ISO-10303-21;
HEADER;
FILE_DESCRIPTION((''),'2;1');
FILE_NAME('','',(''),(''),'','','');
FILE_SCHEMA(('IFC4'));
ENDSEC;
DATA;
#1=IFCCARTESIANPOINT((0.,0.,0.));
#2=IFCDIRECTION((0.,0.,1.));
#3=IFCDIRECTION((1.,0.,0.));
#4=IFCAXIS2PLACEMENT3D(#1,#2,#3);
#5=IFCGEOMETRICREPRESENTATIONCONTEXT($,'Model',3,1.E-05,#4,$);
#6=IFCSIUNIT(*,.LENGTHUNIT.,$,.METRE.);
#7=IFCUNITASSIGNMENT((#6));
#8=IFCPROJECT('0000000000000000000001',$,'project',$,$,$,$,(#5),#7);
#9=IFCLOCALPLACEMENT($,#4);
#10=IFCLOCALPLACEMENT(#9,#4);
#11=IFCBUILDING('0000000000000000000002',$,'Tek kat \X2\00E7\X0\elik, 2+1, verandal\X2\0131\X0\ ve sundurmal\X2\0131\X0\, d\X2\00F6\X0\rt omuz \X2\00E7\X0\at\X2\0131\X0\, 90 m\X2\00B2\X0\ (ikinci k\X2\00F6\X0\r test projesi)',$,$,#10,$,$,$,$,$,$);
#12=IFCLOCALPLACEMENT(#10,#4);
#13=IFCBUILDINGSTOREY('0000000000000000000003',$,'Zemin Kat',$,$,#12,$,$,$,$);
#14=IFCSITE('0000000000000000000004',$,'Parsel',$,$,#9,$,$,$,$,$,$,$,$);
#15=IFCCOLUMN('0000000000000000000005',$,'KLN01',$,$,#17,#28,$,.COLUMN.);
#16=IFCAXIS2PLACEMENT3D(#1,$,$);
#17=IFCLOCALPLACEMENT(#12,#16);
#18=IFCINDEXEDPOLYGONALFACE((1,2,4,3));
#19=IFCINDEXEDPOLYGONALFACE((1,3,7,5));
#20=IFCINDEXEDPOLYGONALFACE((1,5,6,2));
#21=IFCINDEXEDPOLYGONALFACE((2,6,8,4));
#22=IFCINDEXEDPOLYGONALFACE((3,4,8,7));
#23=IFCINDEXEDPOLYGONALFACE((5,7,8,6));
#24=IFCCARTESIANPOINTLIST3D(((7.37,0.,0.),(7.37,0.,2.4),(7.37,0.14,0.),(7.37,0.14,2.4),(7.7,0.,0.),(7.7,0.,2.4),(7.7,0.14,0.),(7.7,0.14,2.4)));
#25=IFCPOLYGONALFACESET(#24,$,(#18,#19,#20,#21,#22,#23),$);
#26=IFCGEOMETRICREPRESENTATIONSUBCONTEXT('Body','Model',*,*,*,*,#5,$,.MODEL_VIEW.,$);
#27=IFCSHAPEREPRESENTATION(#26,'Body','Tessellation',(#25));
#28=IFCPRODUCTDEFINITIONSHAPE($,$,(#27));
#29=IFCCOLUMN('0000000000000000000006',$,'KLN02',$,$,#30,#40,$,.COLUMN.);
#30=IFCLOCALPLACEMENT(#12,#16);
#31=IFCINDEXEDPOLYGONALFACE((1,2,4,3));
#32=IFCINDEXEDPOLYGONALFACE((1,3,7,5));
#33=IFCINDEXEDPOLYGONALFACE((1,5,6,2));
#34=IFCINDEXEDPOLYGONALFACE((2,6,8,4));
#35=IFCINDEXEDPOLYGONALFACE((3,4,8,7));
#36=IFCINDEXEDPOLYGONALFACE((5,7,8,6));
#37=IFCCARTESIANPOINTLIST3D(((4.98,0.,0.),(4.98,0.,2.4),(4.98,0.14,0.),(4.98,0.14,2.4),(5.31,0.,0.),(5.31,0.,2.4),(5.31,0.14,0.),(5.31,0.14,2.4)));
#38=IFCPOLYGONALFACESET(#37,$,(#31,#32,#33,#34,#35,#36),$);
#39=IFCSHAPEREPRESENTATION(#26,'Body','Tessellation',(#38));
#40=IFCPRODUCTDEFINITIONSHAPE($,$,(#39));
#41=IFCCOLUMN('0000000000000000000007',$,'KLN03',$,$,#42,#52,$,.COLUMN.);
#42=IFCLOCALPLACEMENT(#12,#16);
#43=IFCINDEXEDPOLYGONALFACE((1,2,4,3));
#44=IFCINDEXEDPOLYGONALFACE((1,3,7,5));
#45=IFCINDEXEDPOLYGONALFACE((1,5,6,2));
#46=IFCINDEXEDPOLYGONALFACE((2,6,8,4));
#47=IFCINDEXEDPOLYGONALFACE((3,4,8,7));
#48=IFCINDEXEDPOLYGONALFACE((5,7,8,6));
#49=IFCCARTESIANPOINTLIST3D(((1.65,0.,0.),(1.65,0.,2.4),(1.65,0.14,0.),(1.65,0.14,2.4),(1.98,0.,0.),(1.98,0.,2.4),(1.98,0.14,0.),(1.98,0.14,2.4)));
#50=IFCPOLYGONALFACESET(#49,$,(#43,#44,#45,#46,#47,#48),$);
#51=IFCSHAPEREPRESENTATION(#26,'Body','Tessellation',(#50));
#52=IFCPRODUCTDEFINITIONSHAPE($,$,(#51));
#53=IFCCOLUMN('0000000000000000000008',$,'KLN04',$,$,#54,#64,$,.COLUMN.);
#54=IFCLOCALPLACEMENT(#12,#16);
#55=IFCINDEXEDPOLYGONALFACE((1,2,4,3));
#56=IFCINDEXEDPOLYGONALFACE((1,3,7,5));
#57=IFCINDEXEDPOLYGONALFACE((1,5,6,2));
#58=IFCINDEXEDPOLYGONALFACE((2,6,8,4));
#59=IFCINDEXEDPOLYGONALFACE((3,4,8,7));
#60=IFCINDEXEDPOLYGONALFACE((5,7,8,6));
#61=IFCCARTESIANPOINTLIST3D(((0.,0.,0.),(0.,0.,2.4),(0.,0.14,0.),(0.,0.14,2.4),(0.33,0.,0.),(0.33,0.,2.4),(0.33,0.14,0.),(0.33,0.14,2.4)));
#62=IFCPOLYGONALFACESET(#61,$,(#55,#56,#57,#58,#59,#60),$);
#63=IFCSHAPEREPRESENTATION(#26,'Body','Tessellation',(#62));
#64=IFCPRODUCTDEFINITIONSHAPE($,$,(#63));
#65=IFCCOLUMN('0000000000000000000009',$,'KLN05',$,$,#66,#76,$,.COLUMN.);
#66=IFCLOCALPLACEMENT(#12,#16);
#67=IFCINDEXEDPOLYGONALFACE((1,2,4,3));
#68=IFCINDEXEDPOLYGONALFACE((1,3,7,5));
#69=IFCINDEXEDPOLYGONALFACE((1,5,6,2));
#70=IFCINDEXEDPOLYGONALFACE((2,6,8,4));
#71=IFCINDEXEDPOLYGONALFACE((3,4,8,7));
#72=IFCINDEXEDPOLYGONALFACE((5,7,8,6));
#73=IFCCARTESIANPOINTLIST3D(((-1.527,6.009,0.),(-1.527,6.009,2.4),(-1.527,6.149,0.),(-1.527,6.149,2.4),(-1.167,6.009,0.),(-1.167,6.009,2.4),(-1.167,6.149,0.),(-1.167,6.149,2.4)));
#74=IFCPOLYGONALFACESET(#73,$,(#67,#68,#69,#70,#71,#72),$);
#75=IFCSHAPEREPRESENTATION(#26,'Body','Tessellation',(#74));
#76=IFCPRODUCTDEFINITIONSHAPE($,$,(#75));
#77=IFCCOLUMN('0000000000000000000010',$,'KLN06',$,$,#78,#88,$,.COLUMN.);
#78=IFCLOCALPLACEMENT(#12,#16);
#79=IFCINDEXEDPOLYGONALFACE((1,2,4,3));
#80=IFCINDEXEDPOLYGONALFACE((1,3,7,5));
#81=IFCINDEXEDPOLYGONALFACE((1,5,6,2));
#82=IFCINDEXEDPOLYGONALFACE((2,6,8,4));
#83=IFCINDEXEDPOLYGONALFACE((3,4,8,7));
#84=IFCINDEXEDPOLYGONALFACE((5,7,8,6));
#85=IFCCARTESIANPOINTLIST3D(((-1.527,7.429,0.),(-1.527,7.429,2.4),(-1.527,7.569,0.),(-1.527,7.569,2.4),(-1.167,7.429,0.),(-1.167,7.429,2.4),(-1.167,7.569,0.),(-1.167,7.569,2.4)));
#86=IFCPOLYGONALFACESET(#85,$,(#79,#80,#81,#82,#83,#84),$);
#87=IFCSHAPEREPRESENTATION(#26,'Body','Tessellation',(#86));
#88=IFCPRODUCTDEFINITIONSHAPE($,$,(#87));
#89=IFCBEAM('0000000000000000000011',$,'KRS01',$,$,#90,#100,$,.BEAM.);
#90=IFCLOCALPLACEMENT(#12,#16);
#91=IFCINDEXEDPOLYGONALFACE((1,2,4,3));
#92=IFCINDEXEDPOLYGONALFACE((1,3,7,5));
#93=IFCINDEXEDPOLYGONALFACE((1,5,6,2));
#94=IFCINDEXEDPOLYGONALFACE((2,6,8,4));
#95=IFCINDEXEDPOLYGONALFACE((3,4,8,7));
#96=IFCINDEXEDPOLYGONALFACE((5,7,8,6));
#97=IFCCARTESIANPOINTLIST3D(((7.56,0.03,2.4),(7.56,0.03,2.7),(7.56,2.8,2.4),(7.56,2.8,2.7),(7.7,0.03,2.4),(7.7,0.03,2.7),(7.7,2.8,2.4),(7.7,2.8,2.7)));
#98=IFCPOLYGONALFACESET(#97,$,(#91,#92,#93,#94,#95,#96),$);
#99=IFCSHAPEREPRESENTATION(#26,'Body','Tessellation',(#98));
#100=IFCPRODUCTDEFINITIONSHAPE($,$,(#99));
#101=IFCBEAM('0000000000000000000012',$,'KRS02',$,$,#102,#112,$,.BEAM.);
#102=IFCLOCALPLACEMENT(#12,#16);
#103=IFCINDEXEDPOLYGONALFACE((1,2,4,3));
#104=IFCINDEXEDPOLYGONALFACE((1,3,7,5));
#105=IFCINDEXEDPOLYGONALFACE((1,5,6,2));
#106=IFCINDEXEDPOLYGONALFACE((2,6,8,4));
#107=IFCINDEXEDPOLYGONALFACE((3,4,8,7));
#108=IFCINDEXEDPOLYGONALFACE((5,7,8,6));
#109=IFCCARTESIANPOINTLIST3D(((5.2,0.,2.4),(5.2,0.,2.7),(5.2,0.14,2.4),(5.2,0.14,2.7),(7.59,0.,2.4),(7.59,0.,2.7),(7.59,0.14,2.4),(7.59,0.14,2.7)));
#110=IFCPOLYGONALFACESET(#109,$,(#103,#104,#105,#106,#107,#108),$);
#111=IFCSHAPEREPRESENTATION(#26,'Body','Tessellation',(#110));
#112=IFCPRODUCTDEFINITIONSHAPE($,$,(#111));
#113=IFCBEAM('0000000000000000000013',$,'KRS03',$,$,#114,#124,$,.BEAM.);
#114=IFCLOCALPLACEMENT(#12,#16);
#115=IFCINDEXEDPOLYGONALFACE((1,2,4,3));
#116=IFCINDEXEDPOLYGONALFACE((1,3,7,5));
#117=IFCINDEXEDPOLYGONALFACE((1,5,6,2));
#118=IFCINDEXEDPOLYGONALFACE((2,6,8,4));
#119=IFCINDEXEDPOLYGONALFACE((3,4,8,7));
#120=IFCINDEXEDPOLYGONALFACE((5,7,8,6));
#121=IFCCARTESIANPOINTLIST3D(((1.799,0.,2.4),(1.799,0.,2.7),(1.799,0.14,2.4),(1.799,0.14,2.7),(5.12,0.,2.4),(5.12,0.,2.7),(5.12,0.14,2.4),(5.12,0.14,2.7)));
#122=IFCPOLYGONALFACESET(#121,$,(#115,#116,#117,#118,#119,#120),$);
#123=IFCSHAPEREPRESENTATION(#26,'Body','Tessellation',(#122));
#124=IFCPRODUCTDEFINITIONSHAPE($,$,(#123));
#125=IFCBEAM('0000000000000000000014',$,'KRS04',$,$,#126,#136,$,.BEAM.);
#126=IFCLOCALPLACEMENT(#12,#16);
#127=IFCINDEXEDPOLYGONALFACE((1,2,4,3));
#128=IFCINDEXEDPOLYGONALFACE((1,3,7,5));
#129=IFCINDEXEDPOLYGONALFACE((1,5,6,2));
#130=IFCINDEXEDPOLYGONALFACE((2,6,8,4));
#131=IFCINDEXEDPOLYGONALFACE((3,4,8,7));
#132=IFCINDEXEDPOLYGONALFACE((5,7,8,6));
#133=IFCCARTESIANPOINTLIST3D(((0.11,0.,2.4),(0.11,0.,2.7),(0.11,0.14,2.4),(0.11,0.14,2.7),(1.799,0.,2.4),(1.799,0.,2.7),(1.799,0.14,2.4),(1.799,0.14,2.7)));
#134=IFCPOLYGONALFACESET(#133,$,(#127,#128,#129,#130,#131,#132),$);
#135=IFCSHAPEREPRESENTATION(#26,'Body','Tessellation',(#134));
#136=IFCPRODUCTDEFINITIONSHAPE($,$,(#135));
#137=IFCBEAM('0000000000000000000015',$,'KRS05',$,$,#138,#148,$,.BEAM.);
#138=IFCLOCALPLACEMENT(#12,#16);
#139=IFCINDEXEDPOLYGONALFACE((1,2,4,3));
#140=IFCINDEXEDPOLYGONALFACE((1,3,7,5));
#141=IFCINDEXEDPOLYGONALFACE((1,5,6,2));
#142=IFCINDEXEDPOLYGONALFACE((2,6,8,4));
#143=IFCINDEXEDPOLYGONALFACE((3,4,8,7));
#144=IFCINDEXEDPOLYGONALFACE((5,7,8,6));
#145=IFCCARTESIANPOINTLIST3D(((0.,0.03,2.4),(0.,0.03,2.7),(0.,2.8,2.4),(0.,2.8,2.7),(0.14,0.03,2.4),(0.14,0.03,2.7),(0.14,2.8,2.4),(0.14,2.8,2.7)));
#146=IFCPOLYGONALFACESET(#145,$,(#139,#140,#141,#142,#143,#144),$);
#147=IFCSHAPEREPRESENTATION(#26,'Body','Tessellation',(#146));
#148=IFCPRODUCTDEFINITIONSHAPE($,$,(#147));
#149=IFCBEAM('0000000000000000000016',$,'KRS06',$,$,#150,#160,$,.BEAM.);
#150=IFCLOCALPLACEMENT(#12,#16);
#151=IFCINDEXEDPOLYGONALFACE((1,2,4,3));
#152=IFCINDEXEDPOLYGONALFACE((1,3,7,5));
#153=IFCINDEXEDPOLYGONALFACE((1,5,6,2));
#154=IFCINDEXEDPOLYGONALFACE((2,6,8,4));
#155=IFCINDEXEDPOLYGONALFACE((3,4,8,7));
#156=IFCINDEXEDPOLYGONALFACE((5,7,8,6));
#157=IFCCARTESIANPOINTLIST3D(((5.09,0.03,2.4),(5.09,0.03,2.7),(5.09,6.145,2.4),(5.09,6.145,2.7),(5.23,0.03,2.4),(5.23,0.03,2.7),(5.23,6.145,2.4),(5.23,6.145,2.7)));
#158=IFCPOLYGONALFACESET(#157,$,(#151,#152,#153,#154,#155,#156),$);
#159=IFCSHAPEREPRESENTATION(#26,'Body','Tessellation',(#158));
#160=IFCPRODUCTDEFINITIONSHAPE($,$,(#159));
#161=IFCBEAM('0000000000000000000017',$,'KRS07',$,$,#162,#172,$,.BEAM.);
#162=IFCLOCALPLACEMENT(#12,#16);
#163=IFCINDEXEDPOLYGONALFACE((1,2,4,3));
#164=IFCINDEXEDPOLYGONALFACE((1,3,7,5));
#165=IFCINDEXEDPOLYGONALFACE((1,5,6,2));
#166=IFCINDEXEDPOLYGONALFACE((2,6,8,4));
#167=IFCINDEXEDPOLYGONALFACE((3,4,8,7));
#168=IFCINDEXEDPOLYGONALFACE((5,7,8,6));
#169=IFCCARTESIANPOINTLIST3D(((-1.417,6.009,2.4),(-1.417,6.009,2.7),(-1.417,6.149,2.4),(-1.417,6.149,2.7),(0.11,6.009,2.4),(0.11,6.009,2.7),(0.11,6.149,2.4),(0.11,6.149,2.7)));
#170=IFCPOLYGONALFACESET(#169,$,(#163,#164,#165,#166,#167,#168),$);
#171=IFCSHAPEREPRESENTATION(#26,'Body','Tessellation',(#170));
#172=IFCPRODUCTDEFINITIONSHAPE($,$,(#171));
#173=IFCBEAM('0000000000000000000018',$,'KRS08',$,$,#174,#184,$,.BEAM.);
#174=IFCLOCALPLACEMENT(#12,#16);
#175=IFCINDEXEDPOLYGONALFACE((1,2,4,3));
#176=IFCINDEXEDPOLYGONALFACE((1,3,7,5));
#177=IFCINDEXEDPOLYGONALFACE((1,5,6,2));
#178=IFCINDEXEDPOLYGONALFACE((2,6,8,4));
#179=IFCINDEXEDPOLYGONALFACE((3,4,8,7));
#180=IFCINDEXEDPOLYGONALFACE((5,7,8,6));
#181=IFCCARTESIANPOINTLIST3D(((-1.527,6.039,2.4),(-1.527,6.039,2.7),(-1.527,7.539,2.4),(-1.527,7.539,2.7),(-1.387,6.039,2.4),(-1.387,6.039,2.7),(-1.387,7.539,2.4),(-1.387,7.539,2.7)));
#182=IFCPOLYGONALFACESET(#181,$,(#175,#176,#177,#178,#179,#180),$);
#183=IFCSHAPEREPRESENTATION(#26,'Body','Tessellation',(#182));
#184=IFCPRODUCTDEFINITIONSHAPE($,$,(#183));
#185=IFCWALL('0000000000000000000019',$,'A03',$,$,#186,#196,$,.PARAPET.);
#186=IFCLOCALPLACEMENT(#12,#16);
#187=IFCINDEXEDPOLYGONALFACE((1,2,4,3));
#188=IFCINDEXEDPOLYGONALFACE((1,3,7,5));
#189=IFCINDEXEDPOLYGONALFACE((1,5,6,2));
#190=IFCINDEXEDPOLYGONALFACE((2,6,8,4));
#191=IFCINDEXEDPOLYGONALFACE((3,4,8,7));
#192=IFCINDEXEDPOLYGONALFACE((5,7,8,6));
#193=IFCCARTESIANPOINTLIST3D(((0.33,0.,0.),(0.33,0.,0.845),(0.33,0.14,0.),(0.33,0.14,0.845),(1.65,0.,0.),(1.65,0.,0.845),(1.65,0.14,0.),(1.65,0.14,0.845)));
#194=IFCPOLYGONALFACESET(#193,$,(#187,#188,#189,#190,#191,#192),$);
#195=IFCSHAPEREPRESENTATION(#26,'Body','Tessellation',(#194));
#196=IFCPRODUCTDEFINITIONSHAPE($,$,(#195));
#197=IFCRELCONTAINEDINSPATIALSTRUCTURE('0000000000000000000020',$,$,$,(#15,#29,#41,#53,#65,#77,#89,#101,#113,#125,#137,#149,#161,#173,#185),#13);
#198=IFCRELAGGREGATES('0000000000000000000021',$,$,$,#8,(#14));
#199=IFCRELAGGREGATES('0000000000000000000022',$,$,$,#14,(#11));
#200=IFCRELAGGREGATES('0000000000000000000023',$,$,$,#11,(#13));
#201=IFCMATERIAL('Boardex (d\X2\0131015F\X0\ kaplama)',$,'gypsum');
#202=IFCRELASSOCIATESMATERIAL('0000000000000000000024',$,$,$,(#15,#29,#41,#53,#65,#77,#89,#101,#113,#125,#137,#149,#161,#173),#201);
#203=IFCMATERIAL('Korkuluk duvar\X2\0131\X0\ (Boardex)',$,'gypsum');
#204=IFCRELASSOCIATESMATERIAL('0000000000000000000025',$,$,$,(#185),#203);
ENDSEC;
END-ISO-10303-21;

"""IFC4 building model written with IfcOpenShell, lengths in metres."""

from ifc_helpers import new_model, si_unit, frame, origin_with_axes, place, context, subcontext, project, spatial, line, indexed_curve, outline, extrude, material, element, save


model = new_model("IFC4")

# Units and contexts
model_context = context("Model", 3, precision=1e-05, world=origin_with_axes())
body_context = subcontext(model_context, "Body", "Model", "MODEL_VIEW")
ifc_project = project(units=[si_unit("LENGTHUNIT", "METRE")], contexts=[model_context])

# Site, building, storey
site_placement = place(None, origin_with_axes())
site = spatial("IfcSite", under=ifc_project, at=site_placement, Name="Parsel")
building_placement = place(site_placement, origin_with_axes())
building = spatial("IfcBuilding", under=site, at=building_placement, Name="Tek kat çelik, 2+1, verandalı ve sundurmalı, dört omuz çatı, 90 m² (ikinci kör test projesi)")
storey_placement = place(building_placement, origin_with_axes())
storey = spatial("IfcBuildingStorey", under=building, at=storey_placement, Name="Zemin Kat")

# Columns
ifc_material_1 = material(Name="Boardex (dış kaplama)", Category="gypsum")
column_1_placement = place(storey_placement, origin_with_axes())
element("IfcColumn", 1, at=column_1_placement, inside=storey, material=ifc_material_1, Name="KLN01", PredefinedType="COLUMN", context=body_context, shape_type="SweptSolid", body=[
    extrude(outline(indexed_curve([(0.0, 0.0), (0.33, 0.0), (0.33, 0.14), (0.0, 0.14)], segments=[line(1, 2, 3, 4, 1)])), frame((7.37, 0.0, 0.0), z_axis=(0.0, 0.0, 1.0), x_axis=(1.0, 0.0, 0.0)), (0.0, 0.0, 1.0), 2.4),
])
column_2_placement = place(storey_placement, origin_with_axes())
element("IfcColumn", 2, at=column_2_placement, inside=storey, material=ifc_material_1, Name="KLN02", PredefinedType="COLUMN", context=body_context, shape_type="SweptSolid", body=[
    extrude(outline(indexed_curve([(0.0, 0.0), (0.33, 0.0), (0.33, 0.14), (0.0, 0.14)], segments=[line(1, 2, 3, 4, 1)])), frame((4.98, 0.0, 0.0), z_axis=(0.0, 0.0, 1.0), x_axis=(1.0, 0.0, 0.0)), (0.0, 0.0, 1.0), 2.4),
])
column_3_placement = place(storey_placement, origin_with_axes())
element("IfcColumn", 3, at=column_3_placement, inside=storey, material=ifc_material_1, Name="KLN03", PredefinedType="COLUMN", context=body_context, shape_type="SweptSolid", body=[
    extrude(outline(indexed_curve([(0.0, 0.0), (0.33, 0.0), (0.33, 0.14), (0.0, 0.14)], segments=[line(1, 2, 3, 4, 1)])), frame((1.65, 0.0, 0.0), z_axis=(0.0, 0.0, 1.0), x_axis=(1.0, 0.0, 0.0)), (0.0, 0.0, 1.0), 2.4),
])
column_4_placement = place(storey_placement, origin_with_axes())
element("IfcColumn", 4, at=column_4_placement, inside=storey, material=ifc_material_1, Name="KLN04", PredefinedType="COLUMN", context=body_context, shape_type="SweptSolid", body=[
    extrude(outline(indexed_curve([(0.0, 0.0), (0.33, 0.0), (0.33, 0.14), (0.0, 0.14)], segments=[line(1, 2, 3, 4, 1)])), origin_with_axes(), (0.0, 0.0, 1.0), 2.4),
])
column_5_placement = place(storey_placement, origin_with_axes())
element("IfcColumn", 5, at=column_5_placement, inside=storey, material=ifc_material_1, Name="KLN05", PredefinedType="COLUMN", context=body_context, shape_type="SweptSolid", body=[
    extrude(outline(indexed_curve([(0.0, 0.0), (0.36, 0.0), (0.36, 0.14), (0.0, 0.14)], segments=[line(1, 2, 3, 4, 1)])), frame((-1.527, 6.009, 0.0), z_axis=(0.0, 0.0, 1.0), x_axis=(1.0, 0.0, 0.0)), (0.0, 0.0, 1.0), 2.4),
])
column_6_placement = place(storey_placement, origin_with_axes())
element("IfcColumn", 6, at=column_6_placement, inside=storey, material=ifc_material_1, Name="KLN06", PredefinedType="COLUMN", context=body_context, shape_type="SweptSolid", body=[
    extrude(outline(indexed_curve([(0.0, 0.0), (0.36, 0.0), (0.36, 0.14), (0.0, 0.14)], segments=[line(1, 2, 3, 4, 1)])), frame((-1.527, 7.429, 0.0), z_axis=(0.0, 0.0, 1.0), x_axis=(1.0, 0.0, 0.0)), (0.0, 0.0, 1.0), 2.4),
])

# Beams
beam_1_placement = place(storey_placement, origin_with_axes())
element("IfcBeam", 7, at=beam_1_placement, inside=storey, material=ifc_material_1, Name="KRS01", PredefinedType="BEAM", context=body_context, shape_type="SweptSolid", body=[
    extrude(outline(indexed_curve([(0.0, 0.0), (0.14, 0.0), (0.14, 2.77), (0.0, 2.77)], segments=[line(1, 2, 3, 4, 1)])), frame((7.56, 0.03, 2.4), z_axis=(0.0, 0.0, 1.0), x_axis=(1.0, 0.0, 0.0)), (0.0, 0.0, 1.0), 0.3),
])
beam_2_placement = place(storey_placement, origin_with_axes())
element("IfcBeam", 8, at=beam_2_placement, inside=storey, material=ifc_material_1, Name="KRS02", PredefinedType="BEAM", context=body_context, shape_type="SweptSolid", body=[
    extrude(outline(indexed_curve([(0.0, 0.0), (2.39, 0.0), (2.39, 0.14), (0.0, 0.14)], segments=[line(1, 2, 3, 4, 1)])), frame((5.2, 0.0, 2.4), z_axis=(0.0, 0.0, 1.0), x_axis=(1.0, 0.0, 0.0)), (0.0, 0.0, 1.0), 0.3),
])
beam_3_placement = place(storey_placement, origin_with_axes())
element("IfcBeam", 9, at=beam_3_placement, inside=storey, material=ifc_material_1, Name="KRS03", PredefinedType="BEAM", context=body_context, shape_type="SweptSolid", body=[
    extrude(outline(indexed_curve([(0.0, 0.0), (3.321, 0.0), (3.321, 0.14), (0.0, 0.14)], segments=[line(1, 2, 3, 4, 1)])), frame((1.799, 0.0, 2.4), z_axis=(0.0, 0.0, 1.0), x_axis=(1.0, 0.0, 0.0)), (0.0, 0.0, 1.0), 0.3),
])
beam_4_placement = place(storey_placement, origin_with_axes())
element("IfcBeam", 10, at=beam_4_placement, inside=storey, material=ifc_material_1, Name="KRS04", PredefinedType="BEAM", context=body_context, shape_type="SweptSolid", body=[
    extrude(outline(indexed_curve([(0.0, 0.0), (1.689, 0.0), (1.689, 0.14), (0.0, 0.14)], segments=[line(1, 2, 3, 4, 1)])), frame((0.11, 0.0, 2.4), z_axis=(0.0, 0.0, 1.0), x_axis=(1.0, 0.0, 0.0)), (0.0, 0.0, 1.0), 0.3),
])
beam_5_placement = place(storey_placement, origin_with_axes())
element("IfcBeam", 11, at=beam_5_placement, inside=storey, material=ifc_material_1, Name="KRS05", PredefinedType="BEAM", context=body_context, shape_type="SweptSolid", body=[
    extrude(outline(indexed_curve([(0.0, 0.0), (0.14, 0.0), (0.14, 2.77), (0.0, 2.77)], segments=[line(1, 2, 3, 4, 1)])), frame((0.0, 0.03, 2.4), z_axis=(0.0, 0.0, 1.0), x_axis=(1.0, 0.0, 0.0)), (0.0, 0.0, 1.0), 0.3),
])
beam_6_placement = place(storey_placement, origin_with_axes())
element("IfcBeam", 12, at=beam_6_placement, inside=storey, material=ifc_material_1, Name="KRS06", PredefinedType="BEAM", context=body_context, shape_type="SweptSolid", body=[
    extrude(outline(indexed_curve([(0.0, 0.0), (0.14, 0.0), (0.14, 6.115), (0.0, 6.115)], segments=[line(1, 2, 3, 4, 1)])), frame((5.09, 0.03, 2.4), z_axis=(0.0, 0.0, 1.0), x_axis=(1.0, 0.0, 0.0)), (0.0, 0.0, 1.0), 0.3),
])
beam_7_placement = place(storey_placement, origin_with_axes())
element("IfcBeam", 13, at=beam_7_placement, inside=storey, material=ifc_material_1, Name="KRS07", PredefinedType="BEAM", context=body_context, shape_type="SweptSolid", body=[
    extrude(outline(indexed_curve([(0.0, 0.0), (1.527, 0.0), (1.527, 0.14), (0.0, 0.14)], segments=[line(1, 2, 3, 4, 1)])), frame((-1.417, 6.009, 2.4), z_axis=(0.0, 0.0, 1.0), x_axis=(1.0, 0.0, 0.0)), (0.0, 0.0, 1.0), 0.3),
])
beam_8_placement = place(storey_placement, origin_with_axes())
element("IfcBeam", 14, at=beam_8_placement, inside=storey, material=ifc_material_1, Name="KRS08", PredefinedType="BEAM", context=body_context, shape_type="SweptSolid", body=[
    extrude(outline(indexed_curve([(0.0, 0.0), (0.14, 0.0), (0.14, 1.5), (0.0, 1.5)], segments=[line(1, 2, 3, 4, 1)])), frame((-1.527, 6.039, 2.4), z_axis=(0.0, 0.0, 1.0), x_axis=(1.0, 0.0, 0.0)), (0.0, 0.0, 1.0), 0.3),
])

# Wall
ifc_material_2 = material(Name="Korkuluk duvarı (Boardex)", Category="gypsum")
wall_1_placement = place(storey_placement, origin_with_axes())
element("IfcWall", 15, at=wall_1_placement, inside=storey, material=ifc_material_2, Name="A03", PredefinedType="PARAPET", context=body_context, shape_type="SweptSolid", body=[
    extrude(outline(indexed_curve([(0.0, 0.0), (1.32, 0.0), (1.32, 0.14), (0.0, 0.14)], segments=[line(1, 2, 3, 4, 1)])), frame((0.33, 0.0, 0.0), z_axis=(0.0, 0.0, 1.0), x_axis=(1.0, 0.0, 0.0)), (0.0, 0.0, 1.0), 0.845),
])

save(model, "model.ifc")
